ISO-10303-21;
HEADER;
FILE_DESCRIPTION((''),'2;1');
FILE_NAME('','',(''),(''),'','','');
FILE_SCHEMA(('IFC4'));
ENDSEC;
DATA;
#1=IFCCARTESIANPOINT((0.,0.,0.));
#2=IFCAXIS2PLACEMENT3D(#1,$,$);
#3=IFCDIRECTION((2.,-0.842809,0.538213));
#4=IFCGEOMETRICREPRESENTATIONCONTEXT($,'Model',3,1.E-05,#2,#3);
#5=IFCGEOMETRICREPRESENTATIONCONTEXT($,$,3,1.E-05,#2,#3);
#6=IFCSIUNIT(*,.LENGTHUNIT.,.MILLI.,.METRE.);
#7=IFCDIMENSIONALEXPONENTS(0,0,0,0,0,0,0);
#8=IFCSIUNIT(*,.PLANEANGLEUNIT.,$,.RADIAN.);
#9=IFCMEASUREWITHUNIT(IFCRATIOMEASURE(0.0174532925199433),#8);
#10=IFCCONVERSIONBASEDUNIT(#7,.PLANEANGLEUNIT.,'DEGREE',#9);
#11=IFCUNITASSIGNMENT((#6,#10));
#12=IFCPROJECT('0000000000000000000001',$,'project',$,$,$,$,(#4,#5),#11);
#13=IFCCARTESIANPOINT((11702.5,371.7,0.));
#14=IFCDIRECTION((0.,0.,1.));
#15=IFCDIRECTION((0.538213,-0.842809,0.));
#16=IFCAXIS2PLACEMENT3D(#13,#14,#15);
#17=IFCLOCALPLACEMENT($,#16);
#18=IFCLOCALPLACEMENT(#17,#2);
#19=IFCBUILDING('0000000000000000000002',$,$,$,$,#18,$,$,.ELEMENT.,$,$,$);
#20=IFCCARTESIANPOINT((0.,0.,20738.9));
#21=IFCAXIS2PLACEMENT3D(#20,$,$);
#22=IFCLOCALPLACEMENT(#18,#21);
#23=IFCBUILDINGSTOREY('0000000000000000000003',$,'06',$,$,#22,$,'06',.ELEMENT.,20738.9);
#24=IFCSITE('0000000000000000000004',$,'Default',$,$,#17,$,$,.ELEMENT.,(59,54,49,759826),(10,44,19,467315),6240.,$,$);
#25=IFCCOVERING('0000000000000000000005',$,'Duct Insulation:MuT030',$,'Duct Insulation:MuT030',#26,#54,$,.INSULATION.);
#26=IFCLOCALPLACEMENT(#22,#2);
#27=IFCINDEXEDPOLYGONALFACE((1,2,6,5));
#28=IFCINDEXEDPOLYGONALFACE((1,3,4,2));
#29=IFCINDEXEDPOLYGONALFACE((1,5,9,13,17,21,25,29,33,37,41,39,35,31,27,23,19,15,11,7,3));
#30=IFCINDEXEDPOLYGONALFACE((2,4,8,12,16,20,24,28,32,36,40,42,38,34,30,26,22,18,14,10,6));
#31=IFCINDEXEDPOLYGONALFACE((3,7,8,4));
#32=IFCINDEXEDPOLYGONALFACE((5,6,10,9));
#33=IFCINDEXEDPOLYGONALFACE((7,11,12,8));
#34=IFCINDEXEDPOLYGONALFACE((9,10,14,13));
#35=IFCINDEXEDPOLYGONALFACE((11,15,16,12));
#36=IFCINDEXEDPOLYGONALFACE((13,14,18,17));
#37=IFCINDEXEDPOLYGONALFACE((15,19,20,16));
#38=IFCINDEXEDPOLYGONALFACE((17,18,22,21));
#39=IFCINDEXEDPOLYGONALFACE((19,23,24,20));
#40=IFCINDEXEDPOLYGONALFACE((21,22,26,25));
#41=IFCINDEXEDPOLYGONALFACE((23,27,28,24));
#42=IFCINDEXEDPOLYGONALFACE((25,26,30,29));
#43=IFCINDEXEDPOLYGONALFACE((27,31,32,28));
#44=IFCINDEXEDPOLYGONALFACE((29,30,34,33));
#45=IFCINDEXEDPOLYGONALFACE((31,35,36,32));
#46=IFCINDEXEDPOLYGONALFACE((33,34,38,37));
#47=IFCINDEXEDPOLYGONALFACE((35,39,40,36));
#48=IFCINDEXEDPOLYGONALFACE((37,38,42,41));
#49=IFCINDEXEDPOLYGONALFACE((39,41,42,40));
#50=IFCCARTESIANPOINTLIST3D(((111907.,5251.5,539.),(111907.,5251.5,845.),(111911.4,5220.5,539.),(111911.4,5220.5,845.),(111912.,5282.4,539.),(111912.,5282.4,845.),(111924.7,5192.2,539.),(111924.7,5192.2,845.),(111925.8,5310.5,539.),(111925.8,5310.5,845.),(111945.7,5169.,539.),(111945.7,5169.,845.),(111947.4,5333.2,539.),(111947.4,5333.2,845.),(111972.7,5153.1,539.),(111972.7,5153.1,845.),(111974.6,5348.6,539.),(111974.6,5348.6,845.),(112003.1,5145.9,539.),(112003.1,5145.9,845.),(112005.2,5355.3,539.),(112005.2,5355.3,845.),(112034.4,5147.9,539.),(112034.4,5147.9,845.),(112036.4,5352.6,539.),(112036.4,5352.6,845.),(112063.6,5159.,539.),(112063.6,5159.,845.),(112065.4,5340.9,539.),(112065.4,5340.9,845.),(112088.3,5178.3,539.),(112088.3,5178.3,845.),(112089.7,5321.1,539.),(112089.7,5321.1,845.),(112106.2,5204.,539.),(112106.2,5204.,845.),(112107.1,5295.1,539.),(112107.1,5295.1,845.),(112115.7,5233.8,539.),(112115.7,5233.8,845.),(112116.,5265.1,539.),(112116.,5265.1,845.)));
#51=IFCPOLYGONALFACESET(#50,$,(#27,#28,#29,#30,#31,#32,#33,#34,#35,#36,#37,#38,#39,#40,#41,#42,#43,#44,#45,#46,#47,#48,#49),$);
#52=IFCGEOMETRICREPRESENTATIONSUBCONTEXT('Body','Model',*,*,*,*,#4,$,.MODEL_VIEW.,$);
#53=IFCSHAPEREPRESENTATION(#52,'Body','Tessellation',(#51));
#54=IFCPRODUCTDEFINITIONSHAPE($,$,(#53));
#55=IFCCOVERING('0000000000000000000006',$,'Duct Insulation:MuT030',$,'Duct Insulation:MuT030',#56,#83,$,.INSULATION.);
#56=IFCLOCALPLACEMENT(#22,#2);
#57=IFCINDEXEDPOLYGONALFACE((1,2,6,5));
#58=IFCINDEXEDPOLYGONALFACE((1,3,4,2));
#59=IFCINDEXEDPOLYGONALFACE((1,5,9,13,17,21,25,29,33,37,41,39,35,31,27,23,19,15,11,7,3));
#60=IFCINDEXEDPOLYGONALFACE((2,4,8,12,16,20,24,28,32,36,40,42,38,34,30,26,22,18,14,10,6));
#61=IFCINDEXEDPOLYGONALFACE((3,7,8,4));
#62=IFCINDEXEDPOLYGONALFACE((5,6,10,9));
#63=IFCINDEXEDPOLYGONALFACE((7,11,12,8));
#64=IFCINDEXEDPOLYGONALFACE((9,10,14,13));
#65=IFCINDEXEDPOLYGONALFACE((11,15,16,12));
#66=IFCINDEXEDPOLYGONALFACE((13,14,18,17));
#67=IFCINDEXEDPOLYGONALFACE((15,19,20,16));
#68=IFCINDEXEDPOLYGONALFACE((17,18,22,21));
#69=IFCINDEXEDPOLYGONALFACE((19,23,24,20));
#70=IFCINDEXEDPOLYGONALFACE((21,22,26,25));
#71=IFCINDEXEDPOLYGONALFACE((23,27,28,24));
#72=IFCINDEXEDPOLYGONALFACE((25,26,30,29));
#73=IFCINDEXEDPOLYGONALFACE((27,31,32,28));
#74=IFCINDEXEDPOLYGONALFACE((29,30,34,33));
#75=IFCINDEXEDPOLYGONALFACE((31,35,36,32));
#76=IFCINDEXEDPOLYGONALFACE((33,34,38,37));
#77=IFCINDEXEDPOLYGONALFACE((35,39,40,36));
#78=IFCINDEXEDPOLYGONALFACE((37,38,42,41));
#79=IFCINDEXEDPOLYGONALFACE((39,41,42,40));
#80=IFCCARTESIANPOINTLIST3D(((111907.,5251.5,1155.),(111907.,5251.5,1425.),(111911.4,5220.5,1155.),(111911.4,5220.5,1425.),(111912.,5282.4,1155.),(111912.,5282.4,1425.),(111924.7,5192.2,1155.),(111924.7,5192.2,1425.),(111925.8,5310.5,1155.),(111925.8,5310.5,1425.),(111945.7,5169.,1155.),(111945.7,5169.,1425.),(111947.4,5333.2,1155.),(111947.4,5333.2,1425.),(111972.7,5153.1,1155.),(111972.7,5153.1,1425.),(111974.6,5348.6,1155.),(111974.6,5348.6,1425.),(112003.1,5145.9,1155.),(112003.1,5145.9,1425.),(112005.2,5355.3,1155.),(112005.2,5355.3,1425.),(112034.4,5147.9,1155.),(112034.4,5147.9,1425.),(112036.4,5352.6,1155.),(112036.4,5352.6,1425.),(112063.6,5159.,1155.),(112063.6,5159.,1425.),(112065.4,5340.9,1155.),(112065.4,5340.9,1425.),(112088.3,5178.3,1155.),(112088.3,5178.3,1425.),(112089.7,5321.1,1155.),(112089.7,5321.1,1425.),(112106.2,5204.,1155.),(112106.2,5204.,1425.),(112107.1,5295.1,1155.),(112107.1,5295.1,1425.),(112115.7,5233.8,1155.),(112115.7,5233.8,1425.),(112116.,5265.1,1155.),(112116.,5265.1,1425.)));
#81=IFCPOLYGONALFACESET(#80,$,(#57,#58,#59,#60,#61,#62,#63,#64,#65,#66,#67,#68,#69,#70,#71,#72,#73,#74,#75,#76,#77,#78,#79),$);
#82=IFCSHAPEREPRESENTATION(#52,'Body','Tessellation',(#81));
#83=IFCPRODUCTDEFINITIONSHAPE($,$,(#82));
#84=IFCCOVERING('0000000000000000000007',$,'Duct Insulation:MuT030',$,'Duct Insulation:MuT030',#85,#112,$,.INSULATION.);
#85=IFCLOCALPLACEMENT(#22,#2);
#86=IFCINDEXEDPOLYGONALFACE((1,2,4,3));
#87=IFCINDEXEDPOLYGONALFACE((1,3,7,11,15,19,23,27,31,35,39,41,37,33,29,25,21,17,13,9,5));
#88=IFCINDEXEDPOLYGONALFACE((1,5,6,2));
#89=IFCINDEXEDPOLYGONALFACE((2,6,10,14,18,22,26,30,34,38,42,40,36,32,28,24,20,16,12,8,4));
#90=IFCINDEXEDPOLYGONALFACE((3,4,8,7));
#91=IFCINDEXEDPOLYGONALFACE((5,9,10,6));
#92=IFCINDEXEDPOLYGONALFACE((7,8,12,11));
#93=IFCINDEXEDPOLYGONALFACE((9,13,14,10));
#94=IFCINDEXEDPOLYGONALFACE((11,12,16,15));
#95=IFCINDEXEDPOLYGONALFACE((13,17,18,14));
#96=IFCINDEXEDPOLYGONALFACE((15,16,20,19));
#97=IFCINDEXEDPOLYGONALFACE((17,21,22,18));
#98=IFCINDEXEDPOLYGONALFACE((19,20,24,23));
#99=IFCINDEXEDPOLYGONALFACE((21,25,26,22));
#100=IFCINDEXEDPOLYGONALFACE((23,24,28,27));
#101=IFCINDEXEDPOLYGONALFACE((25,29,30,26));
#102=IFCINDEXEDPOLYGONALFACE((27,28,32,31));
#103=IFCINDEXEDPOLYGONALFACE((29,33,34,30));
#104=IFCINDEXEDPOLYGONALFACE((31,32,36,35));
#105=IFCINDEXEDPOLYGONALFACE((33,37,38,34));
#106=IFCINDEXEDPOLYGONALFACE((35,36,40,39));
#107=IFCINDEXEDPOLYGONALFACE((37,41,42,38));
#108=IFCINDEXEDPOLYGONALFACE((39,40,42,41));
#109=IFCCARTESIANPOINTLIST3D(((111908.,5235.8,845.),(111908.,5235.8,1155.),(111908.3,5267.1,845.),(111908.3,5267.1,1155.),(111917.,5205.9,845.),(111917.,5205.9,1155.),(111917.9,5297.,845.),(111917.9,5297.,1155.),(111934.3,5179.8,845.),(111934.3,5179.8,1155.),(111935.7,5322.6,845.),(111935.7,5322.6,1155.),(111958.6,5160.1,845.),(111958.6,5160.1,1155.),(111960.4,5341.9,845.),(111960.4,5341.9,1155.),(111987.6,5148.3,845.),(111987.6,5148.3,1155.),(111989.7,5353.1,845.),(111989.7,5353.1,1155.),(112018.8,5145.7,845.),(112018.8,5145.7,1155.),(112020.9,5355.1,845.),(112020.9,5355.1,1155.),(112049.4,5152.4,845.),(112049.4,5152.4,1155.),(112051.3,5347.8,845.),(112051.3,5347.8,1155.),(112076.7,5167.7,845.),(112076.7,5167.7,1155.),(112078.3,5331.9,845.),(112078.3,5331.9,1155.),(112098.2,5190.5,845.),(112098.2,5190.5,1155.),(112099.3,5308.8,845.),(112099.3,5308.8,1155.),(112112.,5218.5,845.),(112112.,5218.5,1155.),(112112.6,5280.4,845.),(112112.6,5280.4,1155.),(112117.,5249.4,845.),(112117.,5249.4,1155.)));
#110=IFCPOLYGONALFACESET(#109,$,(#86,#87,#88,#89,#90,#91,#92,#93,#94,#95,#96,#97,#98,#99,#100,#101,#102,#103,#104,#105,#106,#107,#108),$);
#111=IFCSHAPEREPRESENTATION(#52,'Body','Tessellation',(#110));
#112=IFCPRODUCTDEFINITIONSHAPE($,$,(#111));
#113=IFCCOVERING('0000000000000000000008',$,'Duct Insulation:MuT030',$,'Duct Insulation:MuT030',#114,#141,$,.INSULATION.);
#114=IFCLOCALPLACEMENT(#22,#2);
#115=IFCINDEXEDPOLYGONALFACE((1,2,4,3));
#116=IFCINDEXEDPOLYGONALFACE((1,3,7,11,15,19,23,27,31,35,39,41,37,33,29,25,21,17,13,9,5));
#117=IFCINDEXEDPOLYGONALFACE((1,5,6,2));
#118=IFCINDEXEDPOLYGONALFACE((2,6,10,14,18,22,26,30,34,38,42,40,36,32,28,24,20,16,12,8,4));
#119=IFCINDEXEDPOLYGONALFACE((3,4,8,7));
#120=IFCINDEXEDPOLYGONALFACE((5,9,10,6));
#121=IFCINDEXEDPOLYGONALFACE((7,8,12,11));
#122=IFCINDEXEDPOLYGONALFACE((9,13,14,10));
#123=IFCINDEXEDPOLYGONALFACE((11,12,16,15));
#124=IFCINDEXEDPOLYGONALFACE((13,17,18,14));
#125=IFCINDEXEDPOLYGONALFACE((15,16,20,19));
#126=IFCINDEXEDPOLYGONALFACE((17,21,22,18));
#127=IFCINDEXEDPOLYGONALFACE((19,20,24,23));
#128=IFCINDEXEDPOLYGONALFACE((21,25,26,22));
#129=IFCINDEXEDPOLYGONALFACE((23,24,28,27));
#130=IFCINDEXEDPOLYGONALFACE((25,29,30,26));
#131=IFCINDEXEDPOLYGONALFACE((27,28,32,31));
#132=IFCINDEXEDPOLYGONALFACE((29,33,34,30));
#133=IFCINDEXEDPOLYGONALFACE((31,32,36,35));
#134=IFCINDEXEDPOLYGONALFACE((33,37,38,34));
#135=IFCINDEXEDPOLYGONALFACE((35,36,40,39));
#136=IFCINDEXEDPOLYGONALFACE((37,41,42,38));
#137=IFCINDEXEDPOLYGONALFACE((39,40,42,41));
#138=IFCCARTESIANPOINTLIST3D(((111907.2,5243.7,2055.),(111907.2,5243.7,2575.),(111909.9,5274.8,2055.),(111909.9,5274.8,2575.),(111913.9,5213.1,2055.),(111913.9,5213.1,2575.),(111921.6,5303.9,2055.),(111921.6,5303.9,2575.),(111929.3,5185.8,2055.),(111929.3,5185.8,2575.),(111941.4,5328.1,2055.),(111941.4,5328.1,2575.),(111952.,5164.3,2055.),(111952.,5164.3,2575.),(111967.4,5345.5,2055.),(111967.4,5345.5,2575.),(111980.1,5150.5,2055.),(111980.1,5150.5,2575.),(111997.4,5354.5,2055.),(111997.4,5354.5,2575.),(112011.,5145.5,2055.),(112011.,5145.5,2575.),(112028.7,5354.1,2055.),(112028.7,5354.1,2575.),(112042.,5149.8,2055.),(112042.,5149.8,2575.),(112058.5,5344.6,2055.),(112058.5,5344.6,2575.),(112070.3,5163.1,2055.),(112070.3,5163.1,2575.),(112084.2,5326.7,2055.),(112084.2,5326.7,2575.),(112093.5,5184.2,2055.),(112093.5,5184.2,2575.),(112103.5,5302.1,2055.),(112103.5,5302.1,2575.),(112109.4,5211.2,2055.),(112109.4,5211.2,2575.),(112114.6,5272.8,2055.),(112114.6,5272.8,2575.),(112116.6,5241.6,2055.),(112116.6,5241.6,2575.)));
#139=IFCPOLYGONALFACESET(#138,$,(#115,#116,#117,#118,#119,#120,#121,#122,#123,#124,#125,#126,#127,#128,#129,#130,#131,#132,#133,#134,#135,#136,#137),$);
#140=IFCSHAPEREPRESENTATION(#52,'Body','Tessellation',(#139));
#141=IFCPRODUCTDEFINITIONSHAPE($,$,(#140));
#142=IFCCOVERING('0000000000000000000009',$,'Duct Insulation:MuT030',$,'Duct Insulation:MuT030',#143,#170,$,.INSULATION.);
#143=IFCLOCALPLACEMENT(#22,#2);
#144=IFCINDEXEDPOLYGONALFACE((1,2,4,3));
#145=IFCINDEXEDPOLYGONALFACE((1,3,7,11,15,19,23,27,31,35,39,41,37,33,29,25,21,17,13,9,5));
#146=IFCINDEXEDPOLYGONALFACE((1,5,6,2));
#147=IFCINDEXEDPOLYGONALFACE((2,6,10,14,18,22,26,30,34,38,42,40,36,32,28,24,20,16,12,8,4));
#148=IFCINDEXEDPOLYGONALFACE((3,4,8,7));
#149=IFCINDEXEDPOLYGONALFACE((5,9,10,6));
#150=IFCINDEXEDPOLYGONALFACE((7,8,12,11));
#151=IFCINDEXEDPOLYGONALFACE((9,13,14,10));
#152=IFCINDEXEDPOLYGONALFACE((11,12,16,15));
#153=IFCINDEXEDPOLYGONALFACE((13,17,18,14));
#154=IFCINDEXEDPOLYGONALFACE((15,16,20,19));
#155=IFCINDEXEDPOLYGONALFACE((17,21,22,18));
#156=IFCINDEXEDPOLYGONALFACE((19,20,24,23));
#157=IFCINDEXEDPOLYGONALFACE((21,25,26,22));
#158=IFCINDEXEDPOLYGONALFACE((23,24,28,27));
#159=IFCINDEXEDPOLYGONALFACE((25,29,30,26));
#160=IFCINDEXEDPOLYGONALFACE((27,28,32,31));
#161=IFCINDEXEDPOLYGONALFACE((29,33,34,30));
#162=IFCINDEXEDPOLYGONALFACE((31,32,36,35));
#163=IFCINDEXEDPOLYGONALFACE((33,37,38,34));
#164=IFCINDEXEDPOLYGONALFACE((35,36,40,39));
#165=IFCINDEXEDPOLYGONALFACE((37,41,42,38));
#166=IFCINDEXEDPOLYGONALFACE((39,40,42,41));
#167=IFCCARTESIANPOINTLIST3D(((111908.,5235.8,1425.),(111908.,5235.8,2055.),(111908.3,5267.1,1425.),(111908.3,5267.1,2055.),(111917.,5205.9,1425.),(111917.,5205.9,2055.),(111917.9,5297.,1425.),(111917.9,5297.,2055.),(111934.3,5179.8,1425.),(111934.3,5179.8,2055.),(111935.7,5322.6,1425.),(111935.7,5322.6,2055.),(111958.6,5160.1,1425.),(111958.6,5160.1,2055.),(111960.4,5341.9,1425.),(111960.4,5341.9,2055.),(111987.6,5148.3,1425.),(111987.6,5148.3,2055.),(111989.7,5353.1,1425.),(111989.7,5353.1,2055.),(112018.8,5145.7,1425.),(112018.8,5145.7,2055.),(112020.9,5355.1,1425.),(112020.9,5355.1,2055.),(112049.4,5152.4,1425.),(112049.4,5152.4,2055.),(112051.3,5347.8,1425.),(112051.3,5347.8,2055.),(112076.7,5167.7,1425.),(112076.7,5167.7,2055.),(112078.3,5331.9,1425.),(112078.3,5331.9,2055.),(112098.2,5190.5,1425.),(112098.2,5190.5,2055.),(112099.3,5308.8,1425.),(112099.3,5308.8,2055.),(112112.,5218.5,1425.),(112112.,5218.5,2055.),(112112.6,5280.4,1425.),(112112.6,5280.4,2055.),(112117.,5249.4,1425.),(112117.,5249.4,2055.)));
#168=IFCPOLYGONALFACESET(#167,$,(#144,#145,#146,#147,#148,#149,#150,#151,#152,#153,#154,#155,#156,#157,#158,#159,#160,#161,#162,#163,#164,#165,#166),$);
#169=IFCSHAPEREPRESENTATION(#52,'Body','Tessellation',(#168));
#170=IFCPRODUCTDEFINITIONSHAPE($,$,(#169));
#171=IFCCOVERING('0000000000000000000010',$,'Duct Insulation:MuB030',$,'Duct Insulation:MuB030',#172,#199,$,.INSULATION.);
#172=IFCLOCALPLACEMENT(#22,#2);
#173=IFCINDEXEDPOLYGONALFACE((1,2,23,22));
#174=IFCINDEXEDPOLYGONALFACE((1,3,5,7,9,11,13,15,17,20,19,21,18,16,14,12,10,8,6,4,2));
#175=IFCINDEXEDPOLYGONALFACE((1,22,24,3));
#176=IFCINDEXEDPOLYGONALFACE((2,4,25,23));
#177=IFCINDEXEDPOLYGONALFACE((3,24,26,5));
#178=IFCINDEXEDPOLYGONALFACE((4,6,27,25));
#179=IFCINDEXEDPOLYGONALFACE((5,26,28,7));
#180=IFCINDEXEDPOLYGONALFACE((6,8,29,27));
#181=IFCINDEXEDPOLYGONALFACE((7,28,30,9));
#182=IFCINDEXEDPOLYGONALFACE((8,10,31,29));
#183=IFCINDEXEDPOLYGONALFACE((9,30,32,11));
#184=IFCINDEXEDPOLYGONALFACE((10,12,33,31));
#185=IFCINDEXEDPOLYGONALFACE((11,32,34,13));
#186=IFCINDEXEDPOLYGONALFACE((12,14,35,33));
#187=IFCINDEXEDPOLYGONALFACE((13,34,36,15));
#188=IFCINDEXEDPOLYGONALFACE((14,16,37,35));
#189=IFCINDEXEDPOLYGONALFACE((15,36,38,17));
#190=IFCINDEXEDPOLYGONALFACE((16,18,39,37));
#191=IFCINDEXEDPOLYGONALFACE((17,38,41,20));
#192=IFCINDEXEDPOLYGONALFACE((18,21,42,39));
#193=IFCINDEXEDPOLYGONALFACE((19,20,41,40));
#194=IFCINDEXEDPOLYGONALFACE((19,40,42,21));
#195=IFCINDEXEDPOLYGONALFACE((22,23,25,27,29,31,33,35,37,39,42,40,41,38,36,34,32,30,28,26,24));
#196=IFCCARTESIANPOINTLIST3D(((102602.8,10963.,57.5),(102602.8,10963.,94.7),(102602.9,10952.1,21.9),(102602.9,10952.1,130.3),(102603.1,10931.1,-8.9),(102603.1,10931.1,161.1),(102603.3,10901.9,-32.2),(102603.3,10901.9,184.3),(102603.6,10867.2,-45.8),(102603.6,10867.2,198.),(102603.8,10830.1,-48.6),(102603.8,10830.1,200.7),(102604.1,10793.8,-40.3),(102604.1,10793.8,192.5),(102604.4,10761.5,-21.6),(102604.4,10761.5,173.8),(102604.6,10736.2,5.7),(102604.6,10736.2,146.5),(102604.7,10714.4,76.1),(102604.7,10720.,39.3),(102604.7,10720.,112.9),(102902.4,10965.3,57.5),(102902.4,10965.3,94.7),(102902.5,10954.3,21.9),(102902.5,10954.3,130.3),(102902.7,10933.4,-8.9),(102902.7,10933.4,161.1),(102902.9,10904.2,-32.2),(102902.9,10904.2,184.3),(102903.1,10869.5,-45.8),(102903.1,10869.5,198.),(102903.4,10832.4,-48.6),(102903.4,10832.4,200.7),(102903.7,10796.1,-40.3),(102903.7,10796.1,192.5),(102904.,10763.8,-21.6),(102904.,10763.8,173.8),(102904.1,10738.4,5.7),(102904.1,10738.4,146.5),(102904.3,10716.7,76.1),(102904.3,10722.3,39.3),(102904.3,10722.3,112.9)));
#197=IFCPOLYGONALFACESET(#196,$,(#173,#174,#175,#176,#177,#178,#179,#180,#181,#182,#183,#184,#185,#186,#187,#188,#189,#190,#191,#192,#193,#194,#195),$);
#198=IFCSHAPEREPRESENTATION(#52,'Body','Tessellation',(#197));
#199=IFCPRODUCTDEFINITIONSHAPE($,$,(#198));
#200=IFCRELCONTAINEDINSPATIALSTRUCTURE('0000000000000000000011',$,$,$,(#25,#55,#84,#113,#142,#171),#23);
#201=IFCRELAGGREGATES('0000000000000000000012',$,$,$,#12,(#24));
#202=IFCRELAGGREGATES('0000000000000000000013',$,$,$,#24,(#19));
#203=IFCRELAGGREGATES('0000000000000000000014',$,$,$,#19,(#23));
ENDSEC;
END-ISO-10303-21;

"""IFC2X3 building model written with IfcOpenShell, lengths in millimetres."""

from ifc_helpers import new_model, entity, si_unit, converted_unit, direction, frame, frame_2d, origin, origin_2d_with_axis, place, context, subcontext, project, spatial, circle, extrude, element, save


model = new_model("IFC2X3")

# Units and contexts
model_context = context("Model", 3, precision=1e-05, world=origin(), true_north=direction((2.0, -0.842809, 0.538213)))
context_of_model = context(None, 3, precision=1e-05, world=origin(), true_north=direction((2.0, -0.842809, 0.538213)))
body_context = subcontext(model_context, "Body", "Model", "MODEL_VIEW")
ifc_project = project(units=[si_unit("LENGTHUNIT", "METRE", prefix="MILLI"), converted_unit("PLANEANGLEUNIT", "DEGREE", entity("IfcRatioMeasure", 0.0174532925199433), si_unit("PLANEANGLEUNIT", "RADIAN"), dimensions=[0, 0, 0, 0, 0, 0, 0])], contexts=[model_context, context_of_model])

# Site, building, storey
site_placement = place(None, frame((11702.5, 371.7, 0.0), z_axis=(0.0, 0.0, 1.0), x_axis=(0.538213, -0.842809, 0.0)))
site = spatial("IfcSite", under=ifc_project, at=site_placement, Name="Default", CompositionType="ELEMENT", RefLatitude=(59, 54, 49, 759826), RefLongitude=(10, 44, 19, 467315), RefElevation=6240.0)
building_placement = place(site_placement, origin())
building = spatial("IfcBuilding", under=site, at=building_placement, CompositionType="ELEMENT")
storey_placement = place(building_placement, frame((0.0, 0.0, 20738.9)))
storey = spatial("IfcBuildingStorey", under=building, at=storey_placement, Name="06", LongName="06", CompositionType="ELEMENT", Elevation=20738.9)

# Coverings
covering_1_placement = place(storey_placement, origin())
element("IfcCovering", 1, at=covering_1_placement, inside=storey, Name="Duct Insulation:MuT030", ObjectType="Duct Insulation:MuT030", PredefinedType="INSULATION", context=body_context, shape_type="SweptSolid", body=[
    extrude(circle(Radius=105.0, at=frame_2d((0.0, 0.0), x_axis=(1.0, 0.0))), frame((112012.0, 5250.5, 539.0), z_axis=(0.0, 0.0, 1.0), x_axis=(-0.999952, 0.00981, 0.0)), (0.0, 0.0, 1.0), 306.0),
])
covering_2_placement = place(storey_placement, origin())
element("IfcCovering", 2, at=covering_2_placement, inside=storey, Name="Duct Insulation:MuT030", ObjectType="Duct Insulation:MuT030", PredefinedType="INSULATION", context=body_context, shape_type="SweptSolid", body=[
    extrude(circle(Radius=105.0, at=frame_2d((0.0, 0.0), x_axis=(1.0, 0.0))), frame((112012.0, 5250.5, 1155.0), z_axis=(0.0, 0.0, 1.0), x_axis=(-0.999952, 0.00981, 0.0)), (0.0, 0.0, 1.0), 270.0),
])
covering_3_placement = place(storey_placement, origin())
element("IfcCovering", 3, at=covering_3_placement, inside=storey, Name="Duct Insulation:MuT030", ObjectType="Duct Insulation:MuT030", PredefinedType="INSULATION", context=body_context, shape_type="SweptSolid", body=[
    extrude(circle(Radius=105.0, at=origin_2d_with_axis()), frame((112012.0, 5250.5, 845.0), z_axis=(0.0, 0.0, 1.0), x_axis=(0.999952, -0.00981, 0.0)), (0.0, 0.0, 1.0), 310.0),
])
covering_4_placement = place(storey_placement, origin())
element("IfcCovering", 4, at=covering_4_placement, inside=storey, Name="Duct Insulation:MuT030", ObjectType="Duct Insulation:MuT030", PredefinedType="INSULATION", context=body_context, shape_type="SweptSolid", body=[
    extrude(circle(Radius=105.0, at=origin_2d_with_axis()), frame((112012.0, 5250.5, 2055.0), z_axis=(0.0, 0.0, 1.0), x_axis=(-0.00981, -0.999952, 0.0)), (0.0, 0.0, 1.0), 520.0),
])
covering_5_placement = place(storey_placement, origin())
element("IfcCovering", 5, at=covering_5_placement, inside=storey, Name="Duct Insulation:MuT030", ObjectType="Duct Insulation:MuT030", PredefinedType="INSULATION", context=body_context, shape_type="SweptSolid", body=[
    extrude(circle(Radius=105.0, at=origin_2d_with_axis()), frame((112012.0, 5250.5, 1425.0), z_axis=(0.0, 0.0, 1.0), x_axis=(0.999952, -0.00981, 0.0)), (0.0, 0.0, 1.0), 630.0),
])
covering_6_placement = place(storey_placement, origin())
element("IfcCovering", 6, at=covering_6_placement, inside=storey, Name="Duct Insulation:MuB030", ObjectType="Duct Insulation:MuB030", PredefinedType="INSULATION", context=body_context, shape_type="SweptSolid", body=[
    extrude(circle(Radius=125.0, at=origin_2d_with_axis()), frame((102603.8, 10839.4, 76.1), z_axis=(0.999971, 0.007643, 0.0), x_axis=(0.007643, -0.999971, 0.0)), (0.0, 0.0, 1.0), 299.6),
])

save(model, "model.ifc")
